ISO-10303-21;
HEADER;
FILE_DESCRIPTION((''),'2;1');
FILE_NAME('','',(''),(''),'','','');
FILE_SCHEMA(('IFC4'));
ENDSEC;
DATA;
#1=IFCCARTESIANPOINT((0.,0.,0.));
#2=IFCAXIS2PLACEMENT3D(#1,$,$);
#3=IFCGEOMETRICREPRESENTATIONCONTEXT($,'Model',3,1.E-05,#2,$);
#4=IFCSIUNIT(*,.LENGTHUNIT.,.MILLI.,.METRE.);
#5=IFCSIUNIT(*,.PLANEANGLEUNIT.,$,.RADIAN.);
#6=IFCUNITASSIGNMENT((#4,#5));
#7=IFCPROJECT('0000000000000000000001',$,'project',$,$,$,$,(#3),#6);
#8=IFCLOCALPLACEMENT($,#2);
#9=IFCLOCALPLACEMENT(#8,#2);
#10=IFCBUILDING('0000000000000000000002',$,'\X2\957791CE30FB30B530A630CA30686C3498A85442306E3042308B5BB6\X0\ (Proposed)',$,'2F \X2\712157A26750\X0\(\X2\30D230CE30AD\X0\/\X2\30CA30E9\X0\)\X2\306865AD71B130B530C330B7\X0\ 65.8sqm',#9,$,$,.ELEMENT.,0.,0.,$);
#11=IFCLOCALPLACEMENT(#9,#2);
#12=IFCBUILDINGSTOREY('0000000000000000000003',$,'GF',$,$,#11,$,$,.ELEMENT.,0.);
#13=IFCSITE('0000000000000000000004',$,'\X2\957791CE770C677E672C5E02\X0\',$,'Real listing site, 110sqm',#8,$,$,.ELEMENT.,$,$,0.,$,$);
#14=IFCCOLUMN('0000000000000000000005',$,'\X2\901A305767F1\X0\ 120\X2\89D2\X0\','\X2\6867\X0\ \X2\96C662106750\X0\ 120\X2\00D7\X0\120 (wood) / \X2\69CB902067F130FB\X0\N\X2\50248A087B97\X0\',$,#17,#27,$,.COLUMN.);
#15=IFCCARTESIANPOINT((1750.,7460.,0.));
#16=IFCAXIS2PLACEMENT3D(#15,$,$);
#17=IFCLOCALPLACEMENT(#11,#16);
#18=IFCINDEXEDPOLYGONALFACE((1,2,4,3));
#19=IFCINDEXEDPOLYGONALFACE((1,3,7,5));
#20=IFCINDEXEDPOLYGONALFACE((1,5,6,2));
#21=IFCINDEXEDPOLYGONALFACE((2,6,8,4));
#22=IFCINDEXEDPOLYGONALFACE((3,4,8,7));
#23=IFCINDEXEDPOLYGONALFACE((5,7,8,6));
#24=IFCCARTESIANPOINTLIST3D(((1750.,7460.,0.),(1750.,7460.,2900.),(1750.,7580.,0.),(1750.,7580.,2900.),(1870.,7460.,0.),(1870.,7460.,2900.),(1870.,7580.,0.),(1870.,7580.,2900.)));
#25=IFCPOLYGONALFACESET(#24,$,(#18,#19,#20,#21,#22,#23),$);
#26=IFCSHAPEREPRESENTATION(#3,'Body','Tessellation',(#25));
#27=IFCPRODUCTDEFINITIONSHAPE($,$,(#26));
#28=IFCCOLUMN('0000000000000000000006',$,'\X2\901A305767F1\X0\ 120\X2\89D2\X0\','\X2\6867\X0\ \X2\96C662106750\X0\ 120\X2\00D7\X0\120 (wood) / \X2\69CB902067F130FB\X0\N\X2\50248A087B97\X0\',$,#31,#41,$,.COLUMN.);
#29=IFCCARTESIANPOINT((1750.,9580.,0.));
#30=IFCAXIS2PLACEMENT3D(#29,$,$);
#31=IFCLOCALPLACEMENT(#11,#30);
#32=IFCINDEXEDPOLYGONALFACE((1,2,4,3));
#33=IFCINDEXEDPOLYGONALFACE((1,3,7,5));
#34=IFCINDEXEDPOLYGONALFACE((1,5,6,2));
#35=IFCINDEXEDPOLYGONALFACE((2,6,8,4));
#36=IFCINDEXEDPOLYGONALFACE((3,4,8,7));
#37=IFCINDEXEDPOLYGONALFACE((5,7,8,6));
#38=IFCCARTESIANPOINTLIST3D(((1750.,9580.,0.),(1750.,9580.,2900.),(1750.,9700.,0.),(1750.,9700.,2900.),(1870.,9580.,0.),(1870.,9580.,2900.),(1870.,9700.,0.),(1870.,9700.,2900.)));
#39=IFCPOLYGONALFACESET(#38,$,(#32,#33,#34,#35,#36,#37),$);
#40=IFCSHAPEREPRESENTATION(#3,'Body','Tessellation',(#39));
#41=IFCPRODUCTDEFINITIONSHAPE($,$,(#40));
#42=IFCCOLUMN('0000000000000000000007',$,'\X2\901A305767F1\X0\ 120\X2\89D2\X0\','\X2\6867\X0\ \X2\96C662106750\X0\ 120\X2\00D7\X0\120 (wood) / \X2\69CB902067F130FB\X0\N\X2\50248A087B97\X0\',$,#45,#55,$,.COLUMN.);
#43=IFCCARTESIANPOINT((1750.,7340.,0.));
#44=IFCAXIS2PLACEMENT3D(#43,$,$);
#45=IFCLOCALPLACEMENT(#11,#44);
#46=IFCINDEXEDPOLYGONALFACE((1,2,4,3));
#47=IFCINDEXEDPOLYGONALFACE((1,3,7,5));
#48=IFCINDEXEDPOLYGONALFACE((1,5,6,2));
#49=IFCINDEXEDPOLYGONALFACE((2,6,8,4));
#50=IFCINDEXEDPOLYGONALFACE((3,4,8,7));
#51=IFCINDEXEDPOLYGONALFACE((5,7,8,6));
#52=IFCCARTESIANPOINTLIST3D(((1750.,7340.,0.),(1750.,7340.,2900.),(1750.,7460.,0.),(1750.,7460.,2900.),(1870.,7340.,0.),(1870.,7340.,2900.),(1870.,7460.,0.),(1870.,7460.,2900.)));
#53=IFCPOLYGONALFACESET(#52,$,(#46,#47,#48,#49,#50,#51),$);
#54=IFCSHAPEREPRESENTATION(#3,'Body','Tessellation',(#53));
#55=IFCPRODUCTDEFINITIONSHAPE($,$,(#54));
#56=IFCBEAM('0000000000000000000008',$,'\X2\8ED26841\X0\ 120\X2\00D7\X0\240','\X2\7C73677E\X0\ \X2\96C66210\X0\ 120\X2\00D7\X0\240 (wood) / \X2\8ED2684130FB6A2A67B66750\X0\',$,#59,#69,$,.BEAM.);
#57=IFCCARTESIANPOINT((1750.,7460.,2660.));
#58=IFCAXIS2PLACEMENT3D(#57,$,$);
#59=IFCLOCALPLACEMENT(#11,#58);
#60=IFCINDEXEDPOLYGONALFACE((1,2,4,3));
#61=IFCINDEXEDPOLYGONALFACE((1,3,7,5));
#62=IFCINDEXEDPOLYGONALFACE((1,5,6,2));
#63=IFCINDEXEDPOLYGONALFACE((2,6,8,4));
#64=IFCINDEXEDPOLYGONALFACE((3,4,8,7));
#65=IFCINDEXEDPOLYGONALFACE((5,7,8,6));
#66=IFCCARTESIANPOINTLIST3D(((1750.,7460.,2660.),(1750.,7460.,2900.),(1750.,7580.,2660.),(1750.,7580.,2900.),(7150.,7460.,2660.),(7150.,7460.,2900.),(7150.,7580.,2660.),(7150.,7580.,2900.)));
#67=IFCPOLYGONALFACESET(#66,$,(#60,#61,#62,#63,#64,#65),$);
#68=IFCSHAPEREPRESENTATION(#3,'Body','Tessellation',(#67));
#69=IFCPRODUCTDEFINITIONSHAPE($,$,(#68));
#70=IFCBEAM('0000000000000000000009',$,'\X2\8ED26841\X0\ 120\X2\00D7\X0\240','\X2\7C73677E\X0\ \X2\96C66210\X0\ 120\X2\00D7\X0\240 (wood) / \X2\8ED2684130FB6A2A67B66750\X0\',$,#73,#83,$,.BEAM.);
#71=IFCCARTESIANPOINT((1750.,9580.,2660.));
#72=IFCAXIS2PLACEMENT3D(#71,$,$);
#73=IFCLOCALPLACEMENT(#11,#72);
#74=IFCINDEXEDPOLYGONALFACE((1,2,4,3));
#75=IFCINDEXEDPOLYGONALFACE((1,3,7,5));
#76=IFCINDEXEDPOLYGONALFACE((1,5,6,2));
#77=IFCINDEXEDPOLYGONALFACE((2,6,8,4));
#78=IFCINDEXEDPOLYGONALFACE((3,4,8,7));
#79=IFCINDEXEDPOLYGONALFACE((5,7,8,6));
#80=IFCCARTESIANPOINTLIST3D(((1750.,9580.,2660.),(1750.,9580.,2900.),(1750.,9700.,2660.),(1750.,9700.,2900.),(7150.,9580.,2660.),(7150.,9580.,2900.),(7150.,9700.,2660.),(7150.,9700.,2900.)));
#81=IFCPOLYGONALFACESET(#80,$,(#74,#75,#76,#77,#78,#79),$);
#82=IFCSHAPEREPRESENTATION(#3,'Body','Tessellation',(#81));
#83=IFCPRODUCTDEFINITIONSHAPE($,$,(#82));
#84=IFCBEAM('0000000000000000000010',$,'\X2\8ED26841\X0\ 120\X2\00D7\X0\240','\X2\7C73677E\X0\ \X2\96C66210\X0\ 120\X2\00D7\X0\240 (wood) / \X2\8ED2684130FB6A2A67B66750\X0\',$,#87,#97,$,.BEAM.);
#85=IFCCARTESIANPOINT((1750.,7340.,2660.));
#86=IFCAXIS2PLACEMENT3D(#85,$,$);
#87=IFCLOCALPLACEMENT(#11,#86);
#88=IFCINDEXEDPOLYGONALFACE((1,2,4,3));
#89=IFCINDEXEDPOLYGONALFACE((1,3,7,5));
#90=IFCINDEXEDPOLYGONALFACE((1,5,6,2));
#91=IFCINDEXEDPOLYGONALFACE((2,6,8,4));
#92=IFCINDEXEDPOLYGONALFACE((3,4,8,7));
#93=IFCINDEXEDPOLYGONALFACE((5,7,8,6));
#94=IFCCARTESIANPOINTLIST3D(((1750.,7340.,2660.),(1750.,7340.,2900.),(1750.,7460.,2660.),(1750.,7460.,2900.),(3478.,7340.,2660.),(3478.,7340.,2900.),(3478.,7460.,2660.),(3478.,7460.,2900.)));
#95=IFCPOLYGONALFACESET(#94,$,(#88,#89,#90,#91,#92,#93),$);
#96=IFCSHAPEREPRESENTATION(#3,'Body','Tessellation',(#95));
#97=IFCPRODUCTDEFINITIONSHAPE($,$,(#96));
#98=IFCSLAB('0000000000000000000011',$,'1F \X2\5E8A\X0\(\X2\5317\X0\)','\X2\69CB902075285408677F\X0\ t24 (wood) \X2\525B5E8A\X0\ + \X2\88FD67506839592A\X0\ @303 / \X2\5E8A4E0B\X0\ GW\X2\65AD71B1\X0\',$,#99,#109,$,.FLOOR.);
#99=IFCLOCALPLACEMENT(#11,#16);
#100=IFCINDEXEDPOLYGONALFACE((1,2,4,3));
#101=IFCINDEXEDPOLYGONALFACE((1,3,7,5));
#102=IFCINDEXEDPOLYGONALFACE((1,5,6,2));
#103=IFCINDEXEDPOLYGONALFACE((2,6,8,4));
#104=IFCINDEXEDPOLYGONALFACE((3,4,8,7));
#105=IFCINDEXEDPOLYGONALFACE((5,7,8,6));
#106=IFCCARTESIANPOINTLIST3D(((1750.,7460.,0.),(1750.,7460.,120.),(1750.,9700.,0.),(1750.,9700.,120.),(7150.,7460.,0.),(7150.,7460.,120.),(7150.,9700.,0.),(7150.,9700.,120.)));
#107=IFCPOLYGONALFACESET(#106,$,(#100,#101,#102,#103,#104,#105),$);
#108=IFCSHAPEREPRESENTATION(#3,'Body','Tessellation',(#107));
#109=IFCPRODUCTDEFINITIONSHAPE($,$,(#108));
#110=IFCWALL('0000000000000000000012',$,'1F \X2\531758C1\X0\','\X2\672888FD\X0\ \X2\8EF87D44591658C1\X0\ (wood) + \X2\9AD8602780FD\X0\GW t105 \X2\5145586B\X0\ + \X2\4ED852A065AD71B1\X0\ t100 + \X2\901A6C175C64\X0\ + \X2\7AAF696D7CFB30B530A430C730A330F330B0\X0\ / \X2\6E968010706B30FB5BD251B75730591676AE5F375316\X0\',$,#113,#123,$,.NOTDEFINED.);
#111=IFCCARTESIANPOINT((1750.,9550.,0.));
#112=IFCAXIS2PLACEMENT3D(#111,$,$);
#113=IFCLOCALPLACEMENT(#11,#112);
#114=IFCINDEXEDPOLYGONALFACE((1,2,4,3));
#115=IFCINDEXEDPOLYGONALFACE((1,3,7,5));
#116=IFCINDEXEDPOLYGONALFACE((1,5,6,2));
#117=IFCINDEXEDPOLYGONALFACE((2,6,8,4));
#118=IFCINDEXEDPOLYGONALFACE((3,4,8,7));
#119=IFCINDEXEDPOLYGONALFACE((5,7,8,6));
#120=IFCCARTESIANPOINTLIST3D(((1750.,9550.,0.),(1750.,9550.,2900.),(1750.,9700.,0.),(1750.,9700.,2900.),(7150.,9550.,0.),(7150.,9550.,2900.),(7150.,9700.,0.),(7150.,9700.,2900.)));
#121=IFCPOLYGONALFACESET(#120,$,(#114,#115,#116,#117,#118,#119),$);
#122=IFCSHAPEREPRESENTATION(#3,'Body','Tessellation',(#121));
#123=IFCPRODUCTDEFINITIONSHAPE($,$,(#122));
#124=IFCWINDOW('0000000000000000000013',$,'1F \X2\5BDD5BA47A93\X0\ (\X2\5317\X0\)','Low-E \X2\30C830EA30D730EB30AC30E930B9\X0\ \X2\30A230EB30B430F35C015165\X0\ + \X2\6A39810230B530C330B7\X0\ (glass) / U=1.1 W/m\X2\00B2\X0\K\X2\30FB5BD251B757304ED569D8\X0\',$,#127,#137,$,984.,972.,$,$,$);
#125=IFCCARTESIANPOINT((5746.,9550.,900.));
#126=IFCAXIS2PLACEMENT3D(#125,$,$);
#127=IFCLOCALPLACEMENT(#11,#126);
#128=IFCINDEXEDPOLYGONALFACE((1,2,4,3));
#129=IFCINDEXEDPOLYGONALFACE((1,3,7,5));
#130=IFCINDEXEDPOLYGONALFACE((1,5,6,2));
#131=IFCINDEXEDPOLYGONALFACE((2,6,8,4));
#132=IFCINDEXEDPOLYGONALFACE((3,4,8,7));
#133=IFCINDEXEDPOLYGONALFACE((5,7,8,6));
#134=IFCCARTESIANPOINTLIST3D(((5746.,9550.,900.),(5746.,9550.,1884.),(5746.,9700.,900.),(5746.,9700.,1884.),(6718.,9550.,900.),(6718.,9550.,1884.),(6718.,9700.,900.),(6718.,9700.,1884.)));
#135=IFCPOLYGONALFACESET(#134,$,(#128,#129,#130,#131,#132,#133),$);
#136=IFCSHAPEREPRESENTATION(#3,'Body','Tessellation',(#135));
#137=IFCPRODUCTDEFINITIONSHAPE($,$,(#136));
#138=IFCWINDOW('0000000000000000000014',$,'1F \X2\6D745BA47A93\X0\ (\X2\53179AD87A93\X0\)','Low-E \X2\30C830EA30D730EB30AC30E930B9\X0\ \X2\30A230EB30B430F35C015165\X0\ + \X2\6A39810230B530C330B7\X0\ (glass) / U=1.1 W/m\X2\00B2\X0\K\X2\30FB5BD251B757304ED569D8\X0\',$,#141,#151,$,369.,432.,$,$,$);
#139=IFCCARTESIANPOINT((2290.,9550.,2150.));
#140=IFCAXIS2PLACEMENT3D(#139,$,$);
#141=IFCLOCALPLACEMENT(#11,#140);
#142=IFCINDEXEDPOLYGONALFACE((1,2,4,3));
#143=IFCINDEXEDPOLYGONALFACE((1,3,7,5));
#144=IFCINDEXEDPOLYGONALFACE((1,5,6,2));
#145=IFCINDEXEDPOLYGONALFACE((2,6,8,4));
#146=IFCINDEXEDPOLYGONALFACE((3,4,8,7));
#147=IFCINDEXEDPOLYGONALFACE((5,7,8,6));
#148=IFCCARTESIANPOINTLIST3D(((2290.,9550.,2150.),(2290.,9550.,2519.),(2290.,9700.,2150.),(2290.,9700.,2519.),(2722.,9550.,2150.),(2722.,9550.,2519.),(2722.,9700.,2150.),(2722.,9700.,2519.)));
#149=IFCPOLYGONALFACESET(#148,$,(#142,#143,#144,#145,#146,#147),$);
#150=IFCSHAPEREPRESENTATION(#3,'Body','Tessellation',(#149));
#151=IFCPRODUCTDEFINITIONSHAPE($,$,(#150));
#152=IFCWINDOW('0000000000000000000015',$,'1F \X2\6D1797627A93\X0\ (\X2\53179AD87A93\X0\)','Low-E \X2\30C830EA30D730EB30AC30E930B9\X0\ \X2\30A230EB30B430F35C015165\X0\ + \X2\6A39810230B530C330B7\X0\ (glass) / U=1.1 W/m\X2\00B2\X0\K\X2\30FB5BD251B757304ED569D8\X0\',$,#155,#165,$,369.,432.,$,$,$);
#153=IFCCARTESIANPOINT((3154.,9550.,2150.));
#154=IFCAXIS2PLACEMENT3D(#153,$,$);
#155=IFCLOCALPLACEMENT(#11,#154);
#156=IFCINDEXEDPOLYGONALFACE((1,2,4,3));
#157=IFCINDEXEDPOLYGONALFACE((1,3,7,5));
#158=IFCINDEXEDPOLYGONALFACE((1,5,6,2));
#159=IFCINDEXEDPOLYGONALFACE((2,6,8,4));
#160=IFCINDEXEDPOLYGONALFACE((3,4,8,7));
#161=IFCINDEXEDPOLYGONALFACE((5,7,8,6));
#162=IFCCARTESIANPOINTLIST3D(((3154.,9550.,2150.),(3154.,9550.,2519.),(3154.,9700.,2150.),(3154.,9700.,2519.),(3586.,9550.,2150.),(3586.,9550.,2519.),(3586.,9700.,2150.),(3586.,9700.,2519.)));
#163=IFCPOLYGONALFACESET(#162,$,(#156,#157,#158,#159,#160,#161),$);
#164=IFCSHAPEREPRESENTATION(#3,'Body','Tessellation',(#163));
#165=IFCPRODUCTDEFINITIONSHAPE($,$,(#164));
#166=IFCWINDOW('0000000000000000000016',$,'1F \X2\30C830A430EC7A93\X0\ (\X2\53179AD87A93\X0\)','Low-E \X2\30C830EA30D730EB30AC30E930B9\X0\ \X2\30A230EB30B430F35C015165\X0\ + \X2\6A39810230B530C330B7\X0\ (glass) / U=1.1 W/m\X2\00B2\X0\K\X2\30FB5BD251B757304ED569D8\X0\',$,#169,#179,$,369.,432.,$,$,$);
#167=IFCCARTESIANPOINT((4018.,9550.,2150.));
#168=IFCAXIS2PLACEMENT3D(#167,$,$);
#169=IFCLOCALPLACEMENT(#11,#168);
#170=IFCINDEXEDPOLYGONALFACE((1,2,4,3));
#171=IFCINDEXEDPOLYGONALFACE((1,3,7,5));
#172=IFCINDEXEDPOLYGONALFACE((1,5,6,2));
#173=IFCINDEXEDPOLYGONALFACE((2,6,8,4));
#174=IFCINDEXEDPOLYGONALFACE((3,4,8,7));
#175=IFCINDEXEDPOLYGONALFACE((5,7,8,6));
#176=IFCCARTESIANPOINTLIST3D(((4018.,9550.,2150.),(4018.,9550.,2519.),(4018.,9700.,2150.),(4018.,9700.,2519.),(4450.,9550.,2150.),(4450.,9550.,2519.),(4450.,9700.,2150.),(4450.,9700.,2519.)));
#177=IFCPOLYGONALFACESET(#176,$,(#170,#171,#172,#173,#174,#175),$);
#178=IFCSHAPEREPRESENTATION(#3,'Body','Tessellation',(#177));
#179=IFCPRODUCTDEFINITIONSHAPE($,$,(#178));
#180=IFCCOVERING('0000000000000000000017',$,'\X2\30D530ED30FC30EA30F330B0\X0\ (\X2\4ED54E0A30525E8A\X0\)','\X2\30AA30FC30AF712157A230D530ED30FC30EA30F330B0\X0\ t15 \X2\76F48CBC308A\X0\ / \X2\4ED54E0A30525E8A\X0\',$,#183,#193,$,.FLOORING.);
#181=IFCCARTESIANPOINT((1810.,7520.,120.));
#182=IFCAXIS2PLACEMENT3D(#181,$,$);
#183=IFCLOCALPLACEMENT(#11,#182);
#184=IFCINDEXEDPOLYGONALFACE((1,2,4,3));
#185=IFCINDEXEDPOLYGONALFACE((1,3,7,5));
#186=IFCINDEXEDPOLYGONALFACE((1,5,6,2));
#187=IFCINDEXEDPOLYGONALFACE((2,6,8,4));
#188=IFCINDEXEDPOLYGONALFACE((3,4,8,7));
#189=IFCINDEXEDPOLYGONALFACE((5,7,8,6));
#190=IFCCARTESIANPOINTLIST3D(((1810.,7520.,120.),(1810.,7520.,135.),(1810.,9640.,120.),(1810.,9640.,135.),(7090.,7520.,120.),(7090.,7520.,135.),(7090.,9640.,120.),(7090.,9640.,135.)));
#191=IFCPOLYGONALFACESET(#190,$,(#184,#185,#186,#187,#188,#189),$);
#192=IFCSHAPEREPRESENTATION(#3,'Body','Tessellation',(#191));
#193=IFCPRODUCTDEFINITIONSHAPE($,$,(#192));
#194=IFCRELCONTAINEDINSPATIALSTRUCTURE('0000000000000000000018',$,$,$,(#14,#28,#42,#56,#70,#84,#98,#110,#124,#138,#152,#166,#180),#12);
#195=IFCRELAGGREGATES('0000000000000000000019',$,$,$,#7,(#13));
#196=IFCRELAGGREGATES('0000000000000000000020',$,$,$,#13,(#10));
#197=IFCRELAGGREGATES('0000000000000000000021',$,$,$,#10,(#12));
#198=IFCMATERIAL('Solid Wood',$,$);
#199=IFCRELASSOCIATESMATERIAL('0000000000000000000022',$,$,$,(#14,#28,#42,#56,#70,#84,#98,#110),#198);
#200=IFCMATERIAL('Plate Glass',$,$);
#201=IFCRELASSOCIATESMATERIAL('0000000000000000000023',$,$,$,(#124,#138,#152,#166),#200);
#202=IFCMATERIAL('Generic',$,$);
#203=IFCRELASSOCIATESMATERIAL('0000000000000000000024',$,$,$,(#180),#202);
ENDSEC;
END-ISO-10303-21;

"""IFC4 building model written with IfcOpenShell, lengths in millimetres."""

from ifc_helpers import new_model, si_unit, frame, frame_2d, origin, place, context, project, spatial, rectangle, extrude, material, element, fill, save


model = new_model("IFC4")

# Units and contexts
model_context = context("Model", 3, precision=1e-05, world=origin())
ifc_project = project(units=[si_unit("LENGTHUNIT", "METRE", prefix="MILLI"), si_unit("PLANEANGLEUNIT", "RADIAN")], contexts=[model_context])

# Site, building, storey
site_placement = place(None, origin())
site = spatial("IfcSite", under=ifc_project, at=site_placement, Name="長野県松本市", ObjectType="Real listing site, 110sqm", CompositionType="ELEMENT", RefElevation=0.0)
building_placement = place(site_placement, origin())
building = spatial("IfcBuilding", under=site, at=building_placement, Name="長野・サウナと水風呂のある家 (Proposed)", ObjectType="2F 無垢材(ヒノキ/ナラ)と断熱サッシ 65.8sqm", CompositionType="ELEMENT", ElevationOfRefHeight=0.0, ElevationOfTerrain=0.0)
storey_placement = place(building_placement, origin())
storey = spatial("IfcBuildingStorey", under=building, at=storey_placement, Name="GF", CompositionType="ELEMENT", Elevation=0.0)

# Columns
ifc_material_1 = material(Name="Solid Wood")
column_1_placement = place(storey_placement, frame((1750.0, 7460.0, 0.0)))
element("IfcColumn", 1, at=column_1_placement, inside=storey, material=ifc_material_1, Name="通し柱 120角", Description="桧 集成材 120×120 (wood) / 構造柱・N値計算", PredefinedType="COLUMN", context=model_context, shape_type="SweptSolid", body=[
    extrude(rectangle(XDim=120.0, YDim=120.0, at=frame_2d((60.0, 60.0))), frame((1750.0, 7460.0, 0.0)), (0.0, 0.0, 1.0), 2900.0),
])
column_2_placement = place(storey_placement, frame((1750.0, 9580.0, 0.0)))
element("IfcColumn", 2, at=column_2_placement, inside=storey, material=ifc_material_1, Name="通し柱 120角", Description="桧 集成材 120×120 (wood) / 構造柱・N値計算", PredefinedType="COLUMN", context=model_context, shape_type="SweptSolid", body=[
    extrude(rectangle(XDim=120.0, YDim=120.0, at=frame_2d((60.0, 60.0))), frame((1750.0, 9580.0, 0.0)), (0.0, 0.0, 1.0), 2900.0),
])
column_3_placement = place(storey_placement, frame((1750.0, 7340.0, 0.0)))
element("IfcColumn", 3, at=column_3_placement, inside=storey, material=ifc_material_1, Name="通し柱 120角", Description="桧 集成材 120×120 (wood) / 構造柱・N値計算", PredefinedType="COLUMN", context=model_context, shape_type="SweptSolid", body=[
    extrude(rectangle(XDim=120.0, YDim=120.0, at=frame_2d((60.0, 60.0))), frame((1750.0, 7340.0, 0.0)), (0.0, 0.0, 1.0), 2900.0),
])

# Beams
beam_1_placement = place(storey_placement, frame((1750.0, 7460.0, 2660.0)))
element("IfcBeam", 4, at=beam_1_placement, inside=storey, material=ifc_material_1, Name="軒桁 120×240", Description="米松 集成 120×240 (wood) / 軒桁・横架材", PredefinedType="BEAM", context=model_context, shape_type="SweptSolid", body=[
    extrude(rectangle(XDim=5400.0, YDim=120.0, at=frame_2d((2700.0, 60.0))), frame((1750.0, 7460.0, 2660.0)), (0.0, 0.0, 1.0), 240.0),
])
beam_2_placement = place(storey_placement, frame((1750.0, 9580.0, 2660.0)))
element("IfcBeam", 5, at=beam_2_placement, inside=storey, material=ifc_material_1, Name="軒桁 120×240", Description="米松 集成 120×240 (wood) / 軒桁・横架材", PredefinedType="BEAM", context=model_context, shape_type="SweptSolid", body=[
    extrude(rectangle(XDim=5400.0, YDim=120.0, at=frame_2d((2700.0, 60.0))), frame((1750.0, 9580.0, 2660.0)), (0.0, 0.0, 1.0), 240.0),
])
beam_3_placement = place(storey_placement, frame((1750.0, 7340.0, 2660.0)))
element("IfcBeam", 6, at=beam_3_placement, inside=storey, material=ifc_material_1, Name="軒桁 120×240", Description="米松 集成 120×240 (wood) / 軒桁・横架材", PredefinedType="BEAM", context=model_context, shape_type="SweptSolid", body=[
    extrude(rectangle(XDim=1728.0, YDim=120.0, at=frame_2d((864.0, 60.0))), frame((1750.0, 7340.0, 2660.0)), (0.0, 0.0, 1.0), 240.0),
])

# Slab
slab_placement = place(storey_placement, frame((1750.0, 7460.0, 0.0)))
element("IfcSlab", 7, at=slab_placement, inside=storey, material=ifc_material_1, Name="1F 床(北)", Description="構造用合板 t24 (wood) 剛床 + 製材根太 @303 / 床下 GW断熱", PredefinedType="FLOOR", context=model_context, shape_type="SweptSolid", body=[
    extrude(rectangle(XDim=5400.0, YDim=2240.0, at=frame_2d((2700.0, 1120.0))), frame((1750.0, 7460.0, 0.0)), (0.0, 0.0, 1.0), 120.0),
])

# Wall, openings, windows
wall_1_placement = place(storey_placement, frame((1750.0, 9550.0, 0.0)))
wall_1 = element("IfcWall", 8, at=wall_1_placement, inside=storey, material=ifc_material_1, Name="1F 北壁", Description="木製 軸組外壁 (wood) + 高性能GW t105 充填 + 付加断熱 t100 + 通気層 + 窯業系サイディング / 準耐火・寒冷地外皮強化", PredefinedType="NOTDEFINED", context=model_context, shape_type="SweptSolid", body=[
    extrude(rectangle(XDim=5400.0, YDim=150.0, at=frame_2d((2700.0, 75.0))), frame((1750.0, 9550.0, 0.0)), (0.0, 0.0, 1.0), 2900.0),
])
opening_1_placement = place(storey_placement, frame((5746.0, 9550.0, 900.0)))
opening_1 = element("IfcOpeningElement", 9, at=opening_1_placement, cuts=wall_1, PredefinedType="NOTDEFINED", context=model_context, shape_type="SweptSolid", body=[
    extrude(rectangle(XDim=972.0, YDim=150.0, at=frame_2d((486.0, 75.0))), frame((5746.0, 9550.0, 900.0)), (0.0, 0.0, 1.0), 984.0),
])
opening_2_placement = place(storey_placement, frame((2290.0, 9550.0, 2150.0)))
opening_2 = element("IfcOpeningElement", 10, at=opening_2_placement, cuts=wall_1, PredefinedType="NOTDEFINED", context=model_context, shape_type="SweptSolid", body=[
    extrude(rectangle(XDim=432.0, YDim=150.0, at=frame_2d((216.0, 75.0))), frame((2290.0, 9550.0, 2150.0)), (0.0, 0.0, 1.0), 369.0),
])
opening_3_placement = place(storey_placement, frame((3154.0, 9550.0, 2150.0)))
opening_3 = element("IfcOpeningElement", 11, at=opening_3_placement, cuts=wall_1, PredefinedType="NOTDEFINED", context=model_context, shape_type="SweptSolid", body=[
    extrude(rectangle(XDim=432.0, YDim=150.0, at=frame_2d((216.0, 75.0))), frame((3154.0, 9550.0, 2150.0)), (0.0, 0.0, 1.0), 369.0),
])
opening_4_placement = place(storey_placement, frame((4018.0, 9550.0, 2150.0)))
opening_4 = element("IfcOpeningElement", 12, at=opening_4_placement, cuts=wall_1, PredefinedType="NOTDEFINED", context=model_context, shape_type="SweptSolid", body=[
    extrude(rectangle(XDim=432.0, YDim=150.0, at=frame_2d((216.0, 75.0))), frame((4018.0, 9550.0, 2150.0)), (0.0, 0.0, 1.0), 369.0),
])
ifc_material_2 = material(Name="Plate Glass")
window_1_placement = place(storey_placement, frame((5746.0, 9550.0, 900.0)))
window_1 = element("IfcWindow", 13, at=window_1_placement, inside=storey, material=ifc_material_2, Name="1F 寝室窓 (北)", Description="Low-E トリプルガラス アルゴン封入 + 樹脂サッシ (glass) / U=1.1 W/m²K・寒冷地仕様", OverallHeight=984.0, OverallWidth=972.0, context=model_context, shape_type="SweptSolid", body=[
    extrude(rectangle(XDim=972.0, YDim=150.0, at=frame_2d((486.0, 75.0))), frame((5746.0, 9550.0, 900.0)), (0.0, 0.0, 1.0), 984.0),
])
fill(opening_1, window_1)
window_2_placement = place(storey_placement, frame((2290.0, 9550.0, 2150.0)))
window_2 = element("IfcWindow", 14, at=window_2_placement, inside=storey, material=ifc_material_2, Name="1F 浴室窓 (北高窓)", Description="Low-E トリプルガラス アルゴン封入 + 樹脂サッシ (glass) / U=1.1 W/m²K・寒冷地仕様", OverallHeight=369.0, OverallWidth=432.0, context=model_context, shape_type="SweptSolid", body=[
    extrude(rectangle(XDim=432.0, YDim=150.0, at=frame_2d((216.0, 75.0))), frame((2290.0, 9550.0, 2150.0)), (0.0, 0.0, 1.0), 369.0),
])
fill(opening_2, window_2)
window_3_placement = place(storey_placement, frame((3154.0, 9550.0, 2150.0)))
window_3 = element("IfcWindow", 15, at=window_3_placement, inside=storey, material=ifc_material_2, Name="1F 洗面窓 (北高窓)", Description="Low-E トリプルガラス アルゴン封入 + 樹脂サッシ (glass) / U=1.1 W/m²K・寒冷地仕様", OverallHeight=369.0, OverallWidth=432.0, context=model_context, shape_type="SweptSolid", body=[
    extrude(rectangle(XDim=432.0, YDim=150.0, at=frame_2d((216.0, 75.0))), frame((3154.0, 9550.0, 2150.0)), (0.0, 0.0, 1.0), 369.0),
])
fill(opening_3, window_3)
window_4_placement = place(storey_placement, frame((4018.0, 9550.0, 2150.0)))
window_4 = element("IfcWindow", 16, at=window_4_placement, inside=storey, material=ifc_material_2, Name="1F トイレ窓 (北高窓)", Description="Low-E トリプルガラス アルゴン封入 + 樹脂サッシ (glass) / U=1.1 W/m²K・寒冷地仕様", OverallHeight=369.0, OverallWidth=432.0, context=model_context, shape_type="SweptSolid", body=[
    extrude(rectangle(XDim=432.0, YDim=150.0, at=frame_2d((216.0, 75.0))), frame((4018.0, 9550.0, 2150.0)), (0.0, 0.0, 1.0), 369.0),
])
fill(opening_4, window_4)

# Covering
ifc_material_3 = material(Name="Generic")
covering_1_placement = place(storey_placement, frame((1810.0, 7520.0, 120.0)))
element("IfcCovering", 17, at=covering_1_placement, inside=storey, material=ifc_material_3, Name="フローリング (仕上げ床)", Description="オーク無垢フローリング t15 直貼り / 仕上げ床", PredefinedType="FLOORING", context=model_context, shape_type="SweptSolid", body=[
    extrude(rectangle(XDim=5280.0, YDim=2120.0, at=frame_2d((2640.0, 1060.0))), frame((1810.0, 7520.0, 120.0)), (0.0, 0.0, 1.0), 15.0),
])

save(model, "model.ifc")
